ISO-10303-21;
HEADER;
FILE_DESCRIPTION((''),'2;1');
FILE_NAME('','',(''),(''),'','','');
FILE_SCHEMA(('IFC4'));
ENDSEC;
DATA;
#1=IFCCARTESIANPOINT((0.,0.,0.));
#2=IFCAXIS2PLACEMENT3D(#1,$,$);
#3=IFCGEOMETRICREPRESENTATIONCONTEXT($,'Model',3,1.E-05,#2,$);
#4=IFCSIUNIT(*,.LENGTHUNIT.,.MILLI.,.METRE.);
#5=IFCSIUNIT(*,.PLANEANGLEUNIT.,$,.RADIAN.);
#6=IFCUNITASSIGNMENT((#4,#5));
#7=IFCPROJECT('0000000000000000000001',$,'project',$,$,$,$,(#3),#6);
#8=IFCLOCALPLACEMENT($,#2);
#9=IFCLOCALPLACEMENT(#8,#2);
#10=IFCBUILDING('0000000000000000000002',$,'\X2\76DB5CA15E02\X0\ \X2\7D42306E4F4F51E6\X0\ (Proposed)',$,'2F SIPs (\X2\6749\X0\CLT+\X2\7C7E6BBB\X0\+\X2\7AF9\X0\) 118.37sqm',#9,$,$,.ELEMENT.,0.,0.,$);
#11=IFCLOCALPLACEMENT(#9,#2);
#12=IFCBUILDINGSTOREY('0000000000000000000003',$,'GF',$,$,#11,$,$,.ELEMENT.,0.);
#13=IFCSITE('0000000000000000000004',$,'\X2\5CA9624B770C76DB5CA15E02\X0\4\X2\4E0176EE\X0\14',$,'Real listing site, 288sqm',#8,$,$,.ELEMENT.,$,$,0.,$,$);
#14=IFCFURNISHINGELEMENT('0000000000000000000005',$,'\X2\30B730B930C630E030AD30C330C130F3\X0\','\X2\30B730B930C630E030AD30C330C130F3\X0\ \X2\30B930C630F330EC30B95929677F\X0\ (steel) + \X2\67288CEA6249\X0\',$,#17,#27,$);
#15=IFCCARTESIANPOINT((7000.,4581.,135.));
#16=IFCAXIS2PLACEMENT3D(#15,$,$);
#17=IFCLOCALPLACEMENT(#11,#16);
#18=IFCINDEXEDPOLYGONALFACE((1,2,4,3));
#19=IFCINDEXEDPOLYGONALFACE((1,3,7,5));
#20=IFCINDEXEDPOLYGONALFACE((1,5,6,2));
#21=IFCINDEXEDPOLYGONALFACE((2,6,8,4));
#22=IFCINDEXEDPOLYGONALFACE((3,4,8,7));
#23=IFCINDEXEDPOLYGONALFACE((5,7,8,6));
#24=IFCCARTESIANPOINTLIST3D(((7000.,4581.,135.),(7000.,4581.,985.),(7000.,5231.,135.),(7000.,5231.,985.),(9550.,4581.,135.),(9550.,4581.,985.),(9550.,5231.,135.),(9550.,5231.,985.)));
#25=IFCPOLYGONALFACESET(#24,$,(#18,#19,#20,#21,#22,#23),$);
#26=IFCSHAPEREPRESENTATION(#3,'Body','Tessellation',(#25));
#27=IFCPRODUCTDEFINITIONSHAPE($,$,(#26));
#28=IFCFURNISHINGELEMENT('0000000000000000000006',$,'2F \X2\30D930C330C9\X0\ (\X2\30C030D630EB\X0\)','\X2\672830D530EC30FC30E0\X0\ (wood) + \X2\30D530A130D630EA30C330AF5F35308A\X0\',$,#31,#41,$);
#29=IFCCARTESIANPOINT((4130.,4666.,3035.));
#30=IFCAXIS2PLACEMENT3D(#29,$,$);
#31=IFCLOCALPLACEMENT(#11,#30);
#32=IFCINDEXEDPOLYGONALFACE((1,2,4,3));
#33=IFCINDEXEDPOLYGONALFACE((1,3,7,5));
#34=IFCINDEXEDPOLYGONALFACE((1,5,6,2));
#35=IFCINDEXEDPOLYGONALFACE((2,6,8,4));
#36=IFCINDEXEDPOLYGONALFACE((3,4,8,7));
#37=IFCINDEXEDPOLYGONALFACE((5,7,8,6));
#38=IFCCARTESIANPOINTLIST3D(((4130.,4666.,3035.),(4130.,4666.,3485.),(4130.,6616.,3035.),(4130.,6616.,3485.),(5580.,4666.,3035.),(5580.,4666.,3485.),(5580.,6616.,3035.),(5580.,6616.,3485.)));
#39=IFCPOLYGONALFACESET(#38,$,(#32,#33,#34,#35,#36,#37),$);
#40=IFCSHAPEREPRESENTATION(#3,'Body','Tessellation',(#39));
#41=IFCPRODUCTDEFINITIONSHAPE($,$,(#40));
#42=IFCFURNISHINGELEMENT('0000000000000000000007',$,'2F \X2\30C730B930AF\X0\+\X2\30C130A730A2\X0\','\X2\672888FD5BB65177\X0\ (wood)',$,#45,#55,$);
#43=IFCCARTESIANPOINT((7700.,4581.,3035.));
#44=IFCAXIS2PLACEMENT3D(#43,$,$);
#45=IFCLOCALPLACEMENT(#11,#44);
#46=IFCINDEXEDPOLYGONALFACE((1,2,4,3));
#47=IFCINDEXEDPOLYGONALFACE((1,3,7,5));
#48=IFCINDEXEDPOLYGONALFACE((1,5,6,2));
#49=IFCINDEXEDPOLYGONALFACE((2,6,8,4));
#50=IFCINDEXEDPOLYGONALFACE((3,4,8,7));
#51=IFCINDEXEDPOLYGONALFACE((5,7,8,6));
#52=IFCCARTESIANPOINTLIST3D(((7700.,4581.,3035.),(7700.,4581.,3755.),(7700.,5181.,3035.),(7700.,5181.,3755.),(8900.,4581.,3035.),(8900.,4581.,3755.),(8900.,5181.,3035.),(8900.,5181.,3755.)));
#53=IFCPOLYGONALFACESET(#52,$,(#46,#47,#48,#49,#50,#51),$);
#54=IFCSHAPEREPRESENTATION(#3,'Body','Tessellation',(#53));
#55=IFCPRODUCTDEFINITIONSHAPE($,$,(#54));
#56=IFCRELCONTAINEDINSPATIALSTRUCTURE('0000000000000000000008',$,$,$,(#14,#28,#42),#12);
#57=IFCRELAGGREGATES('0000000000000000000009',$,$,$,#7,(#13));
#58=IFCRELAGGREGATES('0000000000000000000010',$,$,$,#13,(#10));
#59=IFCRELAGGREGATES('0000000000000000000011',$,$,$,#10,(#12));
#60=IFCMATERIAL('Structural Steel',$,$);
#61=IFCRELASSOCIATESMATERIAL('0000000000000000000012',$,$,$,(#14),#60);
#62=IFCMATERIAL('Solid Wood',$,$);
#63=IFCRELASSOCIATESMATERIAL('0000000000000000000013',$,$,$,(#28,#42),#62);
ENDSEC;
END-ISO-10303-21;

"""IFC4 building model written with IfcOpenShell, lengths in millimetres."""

from ifc_helpers import new_model, si_unit, frame, frame_2d, origin, place, context, project, spatial, rectangle, extrude, material, element, save


model = new_model("IFC4")

# Units and contexts
model_context = context("Model", 3, precision=1e-05, world=origin())
ifc_project = project(units=[si_unit("LENGTHUNIT", "METRE", prefix="MILLI"), si_unit("PLANEANGLEUNIT", "RADIAN")], contexts=[model_context])

# Site, building, storey
site_placement = place(None, origin())
site = spatial("IfcSite", under=ifc_project, at=site_placement, Name="岩手県盛岡市4丁目14", ObjectType="Real listing site, 288sqm", CompositionType="ELEMENT", RefElevation=0.0)
building_placement = place(site_placement, origin())
building = spatial("IfcBuilding", under=site, at=building_placement, Name="盛岡市 終の住処 (Proposed)", ObjectType="2F SIPs (杉CLT+籾殻+竹) 118.37sqm", CompositionType="ELEMENT", ElevationOfRefHeight=0.0, ElevationOfTerrain=0.0)
storey_placement = place(building_placement, origin())
storey = spatial("IfcBuildingStorey", under=building, at=storey_placement, Name="GF", CompositionType="ELEMENT", Elevation=0.0)

# Shared definitions
ifc_material_1 = material(Name="Solid Wood")

# Furnishing elements
ifc_material_2 = material(Name="Structural Steel")
furnishing_1_placement = place(storey_placement, frame((7000.0, 4581.0, 135.0)))
element("IfcFurnishingElement", 1, at=furnishing_1_placement, inside=storey, material=ifc_material_2, Name="システムキッチン", Description="システムキッチン ステンレス天板 (steel) + 木質扉", context=model_context, shape_type="SweptSolid", body=[
    extrude(rectangle(XDim=2550.0, YDim=650.0, at=frame_2d((1275.0, 325.0))), frame((7000.0, 4581.0, 135.0)), (0.0, 0.0, 1.0), 850.0),
])
furnishing_2_placement = place(storey_placement, frame((4130.0, 4666.0, 3035.0)))
element("IfcFurnishingElement", 2, at=furnishing_2_placement, inside=storey, material=ifc_material_1, Name="2F ベッド (ダブル)", Description="木フレーム (wood) + ファブリック張り", context=model_context, shape_type="SweptSolid", body=[
    extrude(rectangle(XDim=1450.0, YDim=1950.0, at=frame_2d((725.0, 975.0))), frame((4130.0, 4666.0, 3035.0)), (0.0, 0.0, 1.0), 450.0),
])
furnishing_3_placement = place(storey_placement, frame((7700.0, 4581.0, 3035.0)))
element("IfcFurnishingElement", 3, at=furnishing_3_placement, inside=storey, material=ifc_material_1, Name="2F デスク+チェア", Description="木製家具 (wood)", context=model_context, shape_type="SweptSolid", body=[
    extrude(rectangle(XDim=1200.0, YDim=600.0, at=frame_2d((600.0, 300.0))), frame((7700.0, 4581.0, 3035.0)), (0.0, 0.0, 1.0), 720.0),
])

save(model, "model.ifc")
